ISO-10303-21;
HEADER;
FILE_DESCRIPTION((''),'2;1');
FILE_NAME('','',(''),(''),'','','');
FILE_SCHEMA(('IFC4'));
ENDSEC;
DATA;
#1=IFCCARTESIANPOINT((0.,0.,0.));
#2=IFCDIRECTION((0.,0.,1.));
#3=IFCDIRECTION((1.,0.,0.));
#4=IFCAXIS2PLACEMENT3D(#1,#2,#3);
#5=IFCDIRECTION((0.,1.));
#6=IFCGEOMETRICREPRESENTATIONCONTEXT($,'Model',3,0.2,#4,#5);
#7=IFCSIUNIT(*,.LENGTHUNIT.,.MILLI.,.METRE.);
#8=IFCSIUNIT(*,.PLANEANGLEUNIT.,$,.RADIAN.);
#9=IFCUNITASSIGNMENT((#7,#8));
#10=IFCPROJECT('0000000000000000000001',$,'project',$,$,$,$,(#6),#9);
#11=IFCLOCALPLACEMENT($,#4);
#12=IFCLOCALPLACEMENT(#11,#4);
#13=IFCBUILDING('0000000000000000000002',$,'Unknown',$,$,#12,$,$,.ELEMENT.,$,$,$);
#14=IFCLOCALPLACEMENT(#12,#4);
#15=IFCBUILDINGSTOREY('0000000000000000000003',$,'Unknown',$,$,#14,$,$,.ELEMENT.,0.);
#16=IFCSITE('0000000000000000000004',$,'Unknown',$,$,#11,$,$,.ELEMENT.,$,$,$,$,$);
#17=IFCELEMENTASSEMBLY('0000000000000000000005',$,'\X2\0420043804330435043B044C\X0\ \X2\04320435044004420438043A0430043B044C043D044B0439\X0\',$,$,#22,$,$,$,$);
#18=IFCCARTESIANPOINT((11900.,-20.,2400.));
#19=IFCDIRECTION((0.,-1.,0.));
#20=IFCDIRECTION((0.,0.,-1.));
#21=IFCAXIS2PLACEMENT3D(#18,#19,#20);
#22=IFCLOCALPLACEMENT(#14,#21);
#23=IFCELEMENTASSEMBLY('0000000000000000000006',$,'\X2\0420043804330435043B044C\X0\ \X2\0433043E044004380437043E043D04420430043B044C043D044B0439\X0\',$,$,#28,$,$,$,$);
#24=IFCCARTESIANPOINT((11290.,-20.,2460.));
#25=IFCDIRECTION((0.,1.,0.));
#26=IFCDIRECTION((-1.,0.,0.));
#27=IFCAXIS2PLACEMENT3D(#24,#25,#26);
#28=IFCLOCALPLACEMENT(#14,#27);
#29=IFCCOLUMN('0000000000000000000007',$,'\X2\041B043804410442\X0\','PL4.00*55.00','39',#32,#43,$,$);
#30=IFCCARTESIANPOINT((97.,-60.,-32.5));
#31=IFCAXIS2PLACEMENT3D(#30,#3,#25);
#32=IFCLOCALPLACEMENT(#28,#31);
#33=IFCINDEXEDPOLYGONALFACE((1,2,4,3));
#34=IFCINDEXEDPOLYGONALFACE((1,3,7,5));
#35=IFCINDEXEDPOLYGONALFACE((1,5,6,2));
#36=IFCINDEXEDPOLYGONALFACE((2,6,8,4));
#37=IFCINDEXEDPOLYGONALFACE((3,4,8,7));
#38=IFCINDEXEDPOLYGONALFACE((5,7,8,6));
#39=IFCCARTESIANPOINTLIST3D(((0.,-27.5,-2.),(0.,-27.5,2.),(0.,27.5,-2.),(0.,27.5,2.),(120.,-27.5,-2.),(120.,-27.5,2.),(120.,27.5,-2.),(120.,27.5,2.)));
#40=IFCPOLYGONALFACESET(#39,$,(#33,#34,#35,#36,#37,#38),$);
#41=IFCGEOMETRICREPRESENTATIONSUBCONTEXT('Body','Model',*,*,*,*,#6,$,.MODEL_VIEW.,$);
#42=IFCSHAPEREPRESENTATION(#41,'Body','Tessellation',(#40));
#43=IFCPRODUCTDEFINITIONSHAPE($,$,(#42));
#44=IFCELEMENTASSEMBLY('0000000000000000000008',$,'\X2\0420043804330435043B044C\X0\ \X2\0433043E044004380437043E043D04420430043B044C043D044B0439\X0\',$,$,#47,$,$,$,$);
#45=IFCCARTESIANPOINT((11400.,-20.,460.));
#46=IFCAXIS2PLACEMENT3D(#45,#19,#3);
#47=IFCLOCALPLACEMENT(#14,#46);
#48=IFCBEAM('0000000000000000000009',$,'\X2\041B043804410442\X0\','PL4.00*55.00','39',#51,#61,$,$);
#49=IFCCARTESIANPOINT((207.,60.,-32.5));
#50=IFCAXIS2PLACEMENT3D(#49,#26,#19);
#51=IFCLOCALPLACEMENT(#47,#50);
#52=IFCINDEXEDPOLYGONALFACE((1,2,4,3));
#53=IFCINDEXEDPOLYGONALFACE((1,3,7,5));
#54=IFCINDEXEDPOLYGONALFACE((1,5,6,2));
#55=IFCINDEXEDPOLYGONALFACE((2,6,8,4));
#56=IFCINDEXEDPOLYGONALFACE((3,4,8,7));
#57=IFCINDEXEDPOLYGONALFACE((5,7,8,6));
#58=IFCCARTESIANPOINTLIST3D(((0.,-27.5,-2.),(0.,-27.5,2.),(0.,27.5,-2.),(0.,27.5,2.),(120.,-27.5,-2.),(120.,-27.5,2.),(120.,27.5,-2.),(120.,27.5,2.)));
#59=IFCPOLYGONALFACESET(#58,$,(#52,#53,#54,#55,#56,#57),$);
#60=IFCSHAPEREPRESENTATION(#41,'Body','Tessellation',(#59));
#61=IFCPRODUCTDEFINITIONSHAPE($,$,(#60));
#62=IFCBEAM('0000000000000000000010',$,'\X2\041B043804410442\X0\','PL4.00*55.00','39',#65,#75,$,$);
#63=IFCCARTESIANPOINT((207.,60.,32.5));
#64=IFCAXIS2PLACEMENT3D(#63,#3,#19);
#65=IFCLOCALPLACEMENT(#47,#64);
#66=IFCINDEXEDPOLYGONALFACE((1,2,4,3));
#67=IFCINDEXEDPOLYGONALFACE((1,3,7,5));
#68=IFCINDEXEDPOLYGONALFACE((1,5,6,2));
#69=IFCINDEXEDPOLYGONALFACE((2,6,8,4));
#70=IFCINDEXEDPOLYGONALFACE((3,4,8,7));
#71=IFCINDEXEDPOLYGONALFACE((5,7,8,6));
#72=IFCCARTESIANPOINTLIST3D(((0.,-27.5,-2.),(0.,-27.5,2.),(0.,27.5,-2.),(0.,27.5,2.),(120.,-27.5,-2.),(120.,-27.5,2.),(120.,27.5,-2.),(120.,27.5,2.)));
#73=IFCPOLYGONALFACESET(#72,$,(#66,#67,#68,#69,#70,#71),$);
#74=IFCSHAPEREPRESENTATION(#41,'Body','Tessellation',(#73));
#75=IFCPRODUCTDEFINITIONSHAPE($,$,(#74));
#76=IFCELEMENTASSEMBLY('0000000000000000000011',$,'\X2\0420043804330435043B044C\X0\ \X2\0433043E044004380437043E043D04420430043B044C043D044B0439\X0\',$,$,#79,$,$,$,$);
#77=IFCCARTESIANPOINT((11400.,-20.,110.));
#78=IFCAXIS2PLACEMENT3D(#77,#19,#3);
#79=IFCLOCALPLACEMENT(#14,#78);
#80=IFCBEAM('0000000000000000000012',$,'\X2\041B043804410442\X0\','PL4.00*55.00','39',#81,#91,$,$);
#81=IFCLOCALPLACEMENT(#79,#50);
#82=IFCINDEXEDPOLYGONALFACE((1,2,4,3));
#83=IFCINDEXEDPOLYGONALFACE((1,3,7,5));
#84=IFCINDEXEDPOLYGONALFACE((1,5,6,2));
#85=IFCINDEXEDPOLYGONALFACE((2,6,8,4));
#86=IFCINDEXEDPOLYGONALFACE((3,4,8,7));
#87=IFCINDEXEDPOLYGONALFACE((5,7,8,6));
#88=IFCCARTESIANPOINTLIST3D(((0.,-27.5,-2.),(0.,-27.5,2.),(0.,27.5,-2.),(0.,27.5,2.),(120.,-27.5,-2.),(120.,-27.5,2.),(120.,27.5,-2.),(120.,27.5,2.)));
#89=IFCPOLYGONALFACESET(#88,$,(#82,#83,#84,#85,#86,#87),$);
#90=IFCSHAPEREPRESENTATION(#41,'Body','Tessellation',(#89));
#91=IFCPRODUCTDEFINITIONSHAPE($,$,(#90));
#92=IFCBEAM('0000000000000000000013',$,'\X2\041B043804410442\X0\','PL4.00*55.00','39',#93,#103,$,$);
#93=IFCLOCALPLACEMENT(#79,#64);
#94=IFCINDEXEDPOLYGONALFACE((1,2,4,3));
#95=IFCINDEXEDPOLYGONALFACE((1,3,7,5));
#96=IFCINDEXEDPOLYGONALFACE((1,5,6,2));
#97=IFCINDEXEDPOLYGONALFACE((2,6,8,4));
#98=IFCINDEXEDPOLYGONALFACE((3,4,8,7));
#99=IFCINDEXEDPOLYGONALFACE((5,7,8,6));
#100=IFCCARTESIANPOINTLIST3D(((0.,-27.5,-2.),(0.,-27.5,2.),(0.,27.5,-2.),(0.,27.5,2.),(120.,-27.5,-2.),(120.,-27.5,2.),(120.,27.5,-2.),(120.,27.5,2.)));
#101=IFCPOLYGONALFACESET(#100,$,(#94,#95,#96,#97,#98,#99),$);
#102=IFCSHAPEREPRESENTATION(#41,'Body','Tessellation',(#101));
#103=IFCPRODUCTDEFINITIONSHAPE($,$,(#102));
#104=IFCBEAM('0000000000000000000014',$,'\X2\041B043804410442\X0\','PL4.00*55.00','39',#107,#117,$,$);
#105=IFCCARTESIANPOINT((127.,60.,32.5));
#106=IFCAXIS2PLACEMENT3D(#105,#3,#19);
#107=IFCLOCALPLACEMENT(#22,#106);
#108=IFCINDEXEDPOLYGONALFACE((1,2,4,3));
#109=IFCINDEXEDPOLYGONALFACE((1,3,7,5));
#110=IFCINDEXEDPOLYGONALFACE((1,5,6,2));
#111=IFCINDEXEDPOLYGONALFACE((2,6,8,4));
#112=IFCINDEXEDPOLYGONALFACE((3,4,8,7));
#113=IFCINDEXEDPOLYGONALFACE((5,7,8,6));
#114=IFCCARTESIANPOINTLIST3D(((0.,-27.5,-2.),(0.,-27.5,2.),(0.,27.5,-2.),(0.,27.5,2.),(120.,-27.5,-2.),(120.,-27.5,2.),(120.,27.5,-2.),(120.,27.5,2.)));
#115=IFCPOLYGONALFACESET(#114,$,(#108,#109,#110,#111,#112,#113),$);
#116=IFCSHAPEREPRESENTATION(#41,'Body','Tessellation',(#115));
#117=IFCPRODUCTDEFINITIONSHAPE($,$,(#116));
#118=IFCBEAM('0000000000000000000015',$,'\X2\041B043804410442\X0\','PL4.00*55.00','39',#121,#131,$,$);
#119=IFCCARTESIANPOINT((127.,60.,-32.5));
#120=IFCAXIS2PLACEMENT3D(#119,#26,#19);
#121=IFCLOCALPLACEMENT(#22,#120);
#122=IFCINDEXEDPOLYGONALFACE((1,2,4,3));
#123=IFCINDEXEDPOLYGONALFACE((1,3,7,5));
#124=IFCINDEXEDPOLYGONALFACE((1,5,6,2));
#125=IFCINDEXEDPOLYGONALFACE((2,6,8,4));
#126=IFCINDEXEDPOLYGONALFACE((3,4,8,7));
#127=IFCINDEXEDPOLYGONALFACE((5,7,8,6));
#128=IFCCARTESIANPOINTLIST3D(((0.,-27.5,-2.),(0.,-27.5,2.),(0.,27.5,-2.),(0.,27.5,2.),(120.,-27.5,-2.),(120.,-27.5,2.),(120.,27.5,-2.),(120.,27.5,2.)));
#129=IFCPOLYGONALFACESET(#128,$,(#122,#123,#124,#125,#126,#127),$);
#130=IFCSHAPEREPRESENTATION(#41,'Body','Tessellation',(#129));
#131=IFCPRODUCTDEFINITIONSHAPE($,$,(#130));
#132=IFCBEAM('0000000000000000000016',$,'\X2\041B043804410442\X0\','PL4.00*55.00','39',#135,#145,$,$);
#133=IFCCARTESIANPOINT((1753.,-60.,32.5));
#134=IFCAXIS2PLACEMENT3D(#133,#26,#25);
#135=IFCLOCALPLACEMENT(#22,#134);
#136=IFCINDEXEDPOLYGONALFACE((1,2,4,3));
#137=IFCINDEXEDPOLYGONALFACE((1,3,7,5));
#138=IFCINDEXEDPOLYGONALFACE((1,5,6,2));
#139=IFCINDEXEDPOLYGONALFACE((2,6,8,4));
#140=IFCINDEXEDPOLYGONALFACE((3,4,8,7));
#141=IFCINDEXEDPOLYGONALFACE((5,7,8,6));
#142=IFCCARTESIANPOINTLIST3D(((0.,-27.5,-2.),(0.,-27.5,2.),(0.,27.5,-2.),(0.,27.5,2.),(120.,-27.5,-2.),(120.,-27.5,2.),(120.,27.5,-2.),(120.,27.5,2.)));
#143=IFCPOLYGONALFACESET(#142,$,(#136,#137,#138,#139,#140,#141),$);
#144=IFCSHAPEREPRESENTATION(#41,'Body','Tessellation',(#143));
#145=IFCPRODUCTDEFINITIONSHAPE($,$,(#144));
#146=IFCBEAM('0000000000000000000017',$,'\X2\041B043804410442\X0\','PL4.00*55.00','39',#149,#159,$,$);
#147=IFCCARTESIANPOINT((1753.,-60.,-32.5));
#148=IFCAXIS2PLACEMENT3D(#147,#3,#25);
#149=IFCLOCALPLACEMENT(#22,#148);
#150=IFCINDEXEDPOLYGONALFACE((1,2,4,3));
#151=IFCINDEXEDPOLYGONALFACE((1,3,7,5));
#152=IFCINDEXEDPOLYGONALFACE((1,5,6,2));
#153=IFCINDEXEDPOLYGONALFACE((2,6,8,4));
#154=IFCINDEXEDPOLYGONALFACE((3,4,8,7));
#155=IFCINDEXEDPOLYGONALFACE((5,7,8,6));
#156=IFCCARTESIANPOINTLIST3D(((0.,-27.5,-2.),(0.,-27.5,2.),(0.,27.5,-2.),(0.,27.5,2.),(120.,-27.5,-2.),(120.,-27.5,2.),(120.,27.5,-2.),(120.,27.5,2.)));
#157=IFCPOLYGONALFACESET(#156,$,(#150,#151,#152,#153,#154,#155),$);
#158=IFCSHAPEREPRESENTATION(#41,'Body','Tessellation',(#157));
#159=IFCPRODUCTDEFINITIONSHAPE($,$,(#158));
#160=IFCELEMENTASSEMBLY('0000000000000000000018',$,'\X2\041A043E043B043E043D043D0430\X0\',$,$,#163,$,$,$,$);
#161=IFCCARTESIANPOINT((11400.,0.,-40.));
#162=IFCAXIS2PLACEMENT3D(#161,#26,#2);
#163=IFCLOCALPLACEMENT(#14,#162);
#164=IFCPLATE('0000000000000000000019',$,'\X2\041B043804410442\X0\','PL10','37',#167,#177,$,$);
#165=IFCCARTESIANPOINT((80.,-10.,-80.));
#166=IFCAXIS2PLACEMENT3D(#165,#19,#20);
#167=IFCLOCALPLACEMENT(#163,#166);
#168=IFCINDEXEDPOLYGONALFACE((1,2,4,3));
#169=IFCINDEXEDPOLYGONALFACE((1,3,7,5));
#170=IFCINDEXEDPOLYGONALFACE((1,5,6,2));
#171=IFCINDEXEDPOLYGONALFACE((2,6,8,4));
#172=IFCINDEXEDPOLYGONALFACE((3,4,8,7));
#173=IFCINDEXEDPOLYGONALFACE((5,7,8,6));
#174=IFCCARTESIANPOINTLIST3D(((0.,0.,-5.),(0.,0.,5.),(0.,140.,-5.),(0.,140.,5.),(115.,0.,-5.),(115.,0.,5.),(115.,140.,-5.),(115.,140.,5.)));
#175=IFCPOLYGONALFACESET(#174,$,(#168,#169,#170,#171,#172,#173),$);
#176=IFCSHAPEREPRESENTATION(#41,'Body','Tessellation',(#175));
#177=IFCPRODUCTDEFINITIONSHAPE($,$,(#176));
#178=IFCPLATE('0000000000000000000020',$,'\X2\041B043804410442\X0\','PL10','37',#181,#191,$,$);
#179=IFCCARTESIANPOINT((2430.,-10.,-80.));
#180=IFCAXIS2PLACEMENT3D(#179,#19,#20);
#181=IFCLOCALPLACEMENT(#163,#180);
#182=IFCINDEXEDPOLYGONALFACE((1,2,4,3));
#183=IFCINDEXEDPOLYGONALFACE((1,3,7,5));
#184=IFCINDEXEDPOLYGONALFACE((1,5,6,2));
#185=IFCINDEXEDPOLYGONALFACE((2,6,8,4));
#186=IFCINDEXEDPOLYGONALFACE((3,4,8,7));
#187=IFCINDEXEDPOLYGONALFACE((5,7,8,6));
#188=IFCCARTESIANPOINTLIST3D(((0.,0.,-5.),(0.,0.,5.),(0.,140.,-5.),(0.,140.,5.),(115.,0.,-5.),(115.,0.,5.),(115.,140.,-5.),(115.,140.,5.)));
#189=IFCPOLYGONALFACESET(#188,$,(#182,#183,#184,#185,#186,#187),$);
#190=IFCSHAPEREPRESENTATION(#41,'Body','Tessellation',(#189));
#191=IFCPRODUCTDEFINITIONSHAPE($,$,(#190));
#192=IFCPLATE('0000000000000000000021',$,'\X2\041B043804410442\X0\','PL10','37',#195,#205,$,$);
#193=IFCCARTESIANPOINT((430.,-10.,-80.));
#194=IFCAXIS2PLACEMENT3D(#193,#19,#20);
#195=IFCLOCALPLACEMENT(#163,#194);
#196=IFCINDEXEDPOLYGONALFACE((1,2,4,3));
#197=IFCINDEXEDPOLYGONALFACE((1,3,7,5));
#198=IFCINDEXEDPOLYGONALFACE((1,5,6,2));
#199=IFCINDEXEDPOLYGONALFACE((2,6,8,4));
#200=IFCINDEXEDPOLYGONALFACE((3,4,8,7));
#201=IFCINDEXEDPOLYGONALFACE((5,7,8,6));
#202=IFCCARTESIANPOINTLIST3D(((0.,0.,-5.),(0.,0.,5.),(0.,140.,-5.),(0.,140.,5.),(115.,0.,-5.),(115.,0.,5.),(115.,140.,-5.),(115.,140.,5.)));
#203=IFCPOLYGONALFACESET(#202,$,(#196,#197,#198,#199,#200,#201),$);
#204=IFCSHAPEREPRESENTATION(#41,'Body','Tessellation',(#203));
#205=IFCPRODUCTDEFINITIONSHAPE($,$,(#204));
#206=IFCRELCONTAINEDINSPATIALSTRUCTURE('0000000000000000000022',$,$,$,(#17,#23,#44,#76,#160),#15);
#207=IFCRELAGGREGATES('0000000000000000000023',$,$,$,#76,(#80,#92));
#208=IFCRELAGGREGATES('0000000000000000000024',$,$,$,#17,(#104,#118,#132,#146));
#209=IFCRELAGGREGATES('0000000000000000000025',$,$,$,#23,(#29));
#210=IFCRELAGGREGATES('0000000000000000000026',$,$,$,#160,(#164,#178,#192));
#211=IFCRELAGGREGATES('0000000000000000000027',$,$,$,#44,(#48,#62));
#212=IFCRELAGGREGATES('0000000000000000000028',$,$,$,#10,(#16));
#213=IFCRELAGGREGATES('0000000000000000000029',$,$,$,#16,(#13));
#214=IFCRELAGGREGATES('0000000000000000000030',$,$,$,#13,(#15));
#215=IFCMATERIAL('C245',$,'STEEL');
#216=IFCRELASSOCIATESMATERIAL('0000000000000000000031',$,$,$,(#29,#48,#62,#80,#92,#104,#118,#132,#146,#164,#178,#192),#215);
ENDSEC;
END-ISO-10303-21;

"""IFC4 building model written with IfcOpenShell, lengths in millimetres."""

from ifc_helpers import new_model, si_unit, direction, frame, origin_with_axes, place, context, subcontext, project, spatial, line, indexed_curve, outline, extrude, material, element, aggregate, save


model = new_model("IFC4")

# Units and contexts
model_context = context("Model", 3, precision=0.2, world=origin_with_axes(), true_north=direction((0.0, 1.0)))
body_context = subcontext(model_context, "Body", "Model", "MODEL_VIEW")
ifc_project = project(units=[si_unit("LENGTHUNIT", "METRE", prefix="MILLI"), si_unit("PLANEANGLEUNIT", "RADIAN")], contexts=[model_context])

# Site, building, storey
site_placement = place(None, origin_with_axes())
site = spatial("IfcSite", under=ifc_project, at=site_placement, Name="Unknown", CompositionType="ELEMENT")
building_placement = place(site_placement, origin_with_axes())
building = spatial("IfcBuilding", under=site, at=building_placement, Name="Unknown", CompositionType="ELEMENT")
storey_placement = place(building_placement, origin_with_axes())
storey = spatial("IfcBuildingStorey", under=building, at=storey_placement, Name="Unknown", CompositionType="ELEMENT", Elevation=0.0)

# Element assemblies, column
ifc_material_1 = material(Name="C245", Category="STEEL")
assembly_1_placement = place(storey_placement, frame((11900.0, -20.0, 2400.0), z_axis=(0.0, -1.0, 0.0), x_axis=(0.0, 0.0, -1.0)))
assembly_1 = element("IfcElementAssembly", 1, at=assembly_1_placement, inside=storey, Name="Ригель вертикальный")
assembly_2_placement = place(storey_placement, frame((11290.0, -20.0, 2460.0), z_axis=(0.0, 1.0, 0.0), x_axis=(-1.0, 0.0, 0.0)))
assembly_2 = element("IfcElementAssembly", 2, at=assembly_2_placement, inside=storey, Name="Ригель горизонтальный")
column_1_placement = place(assembly_2_placement, frame((97.0, -60.0, -32.5), z_axis=(1.0, 0.0, 0.0), x_axis=(0.0, 1.0, 0.0)))
column_1 = element("IfcColumn", 3, at=column_1_placement, material=ifc_material_1, Name="Лист", Description="PL4.00*55.00", ObjectType="39", context=body_context, shape_type="SolidModel", body=[
    extrude(outline(indexed_curve([(-2.0, -27.5), (2.0, -27.5), (2.0, 27.5), (-2.0, 27.5)], segments=[line(1, 2, 3, 4, 1)])), frame((0.0, 0.0, 0.0), z_axis=(-1.0, 0.0, 0.0), x_axis=(0.0, 0.0, 1.0)), (0.0, 0.0, -1.0), 120.0),
])

# Element assemblies, beams
assembly_3_placement = place(storey_placement, frame((11400.0, -20.0, 460.0), z_axis=(0.0, -1.0, 0.0), x_axis=(1.0, 0.0, 0.0)))
assembly_3 = element("IfcElementAssembly", 4, at=assembly_3_placement, inside=storey, Name="Ригель горизонтальный")
beam_1_placement = place(assembly_3_placement, frame((207.0, 60.0, -32.5), z_axis=(-1.0, 0.0, 0.0), x_axis=(0.0, -1.0, 0.0)))
beam_1 = element("IfcBeam", 5, at=beam_1_placement, material=ifc_material_1, Name="Лист", Description="PL4.00*55.00", ObjectType="39", context=body_context, shape_type="SolidModel", body=[
    extrude(outline(indexed_curve([(-2.0, -27.5), (2.0, -27.5), (2.0, 27.5), (-2.0, 27.5)], segments=[line(1, 2, 3, 4, 1)])), frame((0.0, 0.0, 0.0), z_axis=(-1.0, 0.0, 0.0), x_axis=(0.0, 0.0, 1.0)), (0.0, 0.0, -1.0), 120.0),
])
beam_2_placement = place(assembly_3_placement, frame((207.0, 60.0, 32.5), z_axis=(1.0, 0.0, 0.0), x_axis=(0.0, -1.0, 0.0)))
beam_2 = element("IfcBeam", 6, at=beam_2_placement, material=ifc_material_1, Name="Лист", Description="PL4.00*55.00", ObjectType="39", context=body_context, shape_type="SolidModel", body=[
    extrude(outline(indexed_curve([(-2.0, -27.5), (2.0, -27.5), (2.0, 27.5), (-2.0, 27.5)], segments=[line(1, 2, 3, 4, 1)])), frame((0.0, 0.0, 0.0), z_axis=(-1.0, 0.0, 0.0), x_axis=(0.0, 0.0, 1.0)), (0.0, 0.0, -1.0), 120.0),
])
assembly_4_placement = place(storey_placement, frame((11400.0, -20.0, 110.0), z_axis=(0.0, -1.0, 0.0), x_axis=(1.0, 0.0, 0.0)))
assembly_4 = element("IfcElementAssembly", 7, at=assembly_4_placement, inside=storey, Name="Ригель горизонтальный")
beam_3_placement = place(assembly_4_placement, frame((207.0, 60.0, -32.5), z_axis=(-1.0, 0.0, 0.0), x_axis=(0.0, -1.0, 0.0)))
beam_3 = element("IfcBeam", 8, at=beam_3_placement, material=ifc_material_1, Name="Лист", Description="PL4.00*55.00", ObjectType="39", context=body_context, shape_type="SolidModel", body=[
    extrude(outline(indexed_curve([(-2.0, -27.5), (2.0, -27.5), (2.0, 27.5), (-2.0, 27.5)], segments=[line(1, 2, 3, 4, 1)])), frame((0.0, 0.0, 0.0), z_axis=(-1.0, 0.0, 0.0), x_axis=(0.0, 0.0, 1.0)), (0.0, 0.0, -1.0), 120.0),
])
beam_4_placement = place(assembly_4_placement, frame((207.0, 60.0, 32.5), z_axis=(1.0, 0.0, 0.0), x_axis=(0.0, -1.0, 0.0)))
beam_4 = element("IfcBeam", 9, at=beam_4_placement, material=ifc_material_1, Name="Лист", Description="PL4.00*55.00", ObjectType="39", context=body_context, shape_type="SolidModel", body=[
    extrude(outline(indexed_curve([(-2.0, -27.5), (2.0, -27.5), (2.0, 27.5), (-2.0, 27.5)], segments=[line(1, 2, 3, 4, 1)])), frame((0.0, 0.0, 0.0), z_axis=(-1.0, 0.0, 0.0), x_axis=(0.0, 0.0, 1.0)), (0.0, 0.0, -1.0), 120.0),
])
aggregate(assembly_4, [beam_3, beam_4])

# Beams
beam_5_placement = place(assembly_1_placement, frame((127.0, 60.0, 32.5), z_axis=(1.0, 0.0, 0.0), x_axis=(0.0, -1.0, 0.0)))
beam_5 = element("IfcBeam", 10, at=beam_5_placement, material=ifc_material_1, Name="Лист", Description="PL4.00*55.00", ObjectType="39", context=body_context, shape_type="SolidModel", body=[
    extrude(outline(indexed_curve([(-2.0, -27.5), (2.0, -27.5), (2.0, 27.5), (-2.0, 27.5)], segments=[line(1, 2, 3, 4, 1)])), frame((0.0, 0.0, 0.0), z_axis=(-1.0, 0.0, 0.0), x_axis=(0.0, 0.0, 1.0)), (0.0, 0.0, -1.0), 120.0),
])
beam_6_placement = place(assembly_1_placement, frame((127.0, 60.0, -32.5), z_axis=(-1.0, 0.0, 0.0), x_axis=(0.0, -1.0, 0.0)))
beam_6 = element("IfcBeam", 11, at=beam_6_placement, material=ifc_material_1, Name="Лист", Description="PL4.00*55.00", ObjectType="39", context=body_context, shape_type="SolidModel", body=[
    extrude(outline(indexed_curve([(-2.0, -27.5), (2.0, -27.5), (2.0, 27.5), (-2.0, 27.5)], segments=[line(1, 2, 3, 4, 1)])), frame((0.0, 0.0, 0.0), z_axis=(-1.0, 0.0, 0.0), x_axis=(0.0, 0.0, 1.0)), (0.0, 0.0, -1.0), 120.0),
])
beam_7_placement = place(assembly_1_placement, frame((1753.0, -60.0, 32.5), z_axis=(-1.0, 0.0, 0.0), x_axis=(0.0, 1.0, 0.0)))
beam_7 = element("IfcBeam", 12, at=beam_7_placement, material=ifc_material_1, Name="Лист", Description="PL4.00*55.00", ObjectType="39", context=body_context, shape_type="SolidModel", body=[
    extrude(outline(indexed_curve([(-2.0, -27.5), (2.0, -27.5), (2.0, 27.5), (-2.0, 27.5)], segments=[line(1, 2, 3, 4, 1)])), frame((0.0, 0.0, 0.0), z_axis=(-1.0, 0.0, 0.0), x_axis=(0.0, 0.0, 1.0)), (0.0, 0.0, -1.0), 120.0),
])
beam_8_placement = place(assembly_1_placement, frame((1753.0, -60.0, -32.5), z_axis=(1.0, 0.0, 0.0), x_axis=(0.0, 1.0, 0.0)))
beam_8 = element("IfcBeam", 13, at=beam_8_placement, material=ifc_material_1, Name="Лист", Description="PL4.00*55.00", ObjectType="39", context=body_context, shape_type="SolidModel", body=[
    extrude(outline(indexed_curve([(-2.0, -27.5), (2.0, -27.5), (2.0, 27.5), (-2.0, 27.5)], segments=[line(1, 2, 3, 4, 1)])), frame((0.0, 0.0, 0.0), z_axis=(-1.0, 0.0, 0.0), x_axis=(0.0, 0.0, 1.0)), (0.0, 0.0, -1.0), 120.0),
])
aggregate(assembly_1, [beam_5, beam_6, beam_7, beam_8])

# Element assembly, plates
assembly_5_placement = place(storey_placement, frame((11400.0, 0.0, -40.0), z_axis=(-1.0, 0.0, 0.0), x_axis=(0.0, 0.0, 1.0)))
assembly_5 = element("IfcElementAssembly", 14, at=assembly_5_placement, inside=storey, Name="Колонна")
plate_1_placement = place(assembly_5_placement, frame((80.0, -10.0, -80.0), z_axis=(0.0, -1.0, 0.0), x_axis=(0.0, 0.0, -1.0)))
plate_1 = element("IfcPlate", 15, at=plate_1_placement, material=ifc_material_1, Name="Лист", Description="PL10", ObjectType="37", context=body_context, shape_type="SolidModel", body=[
    extrude(outline(indexed_curve([(0.0, 0.0), (115.0, 0.0), (115.0, 140.0), (0.0, 140.0)], segments=[line(1, 2, 3, 4, 1)])), frame((0.0, 0.0, 5.0), z_axis=(0.0, 0.0, 1.0), x_axis=(1.0, 0.0, 0.0)), (0.0, 0.0, -1.0), 10.0),
])
plate_2_placement = place(assembly_5_placement, frame((2430.0, -10.0, -80.0), z_axis=(0.0, -1.0, 0.0), x_axis=(0.0, 0.0, -1.0)))
plate_2 = element("IfcPlate", 16, at=plate_2_placement, material=ifc_material_1, Name="Лист", Description="PL10", ObjectType="37", context=body_context, shape_type="SolidModel", body=[
    extrude(outline(indexed_curve([(0.0, 0.0), (115.0, 0.0), (115.0, 140.0), (0.0, 140.0)], segments=[line(1, 2, 3, 4, 1)])), frame((0.0, 0.0, 5.0), z_axis=(0.0, 0.0, 1.0), x_axis=(1.0, 0.0, 0.0)), (0.0, 0.0, -1.0), 10.0),
])
plate_3_placement = place(assembly_5_placement, frame((430.0, -10.0, -80.0), z_axis=(0.0, -1.0, 0.0), x_axis=(0.0, 0.0, -1.0)))
plate_3 = element("IfcPlate", 17, at=plate_3_placement, material=ifc_material_1, Name="Лист", Description="PL10", ObjectType="37", context=body_context, shape_type="SolidModel", body=[
    extrude(outline(indexed_curve([(0.0, 0.0), (115.0, 0.0), (115.0, 140.0), (0.0, 140.0)], segments=[line(1, 2, 3, 4, 1)])), frame((0.0, 0.0, 5.0), z_axis=(0.0, 0.0, 1.0), x_axis=(1.0, 0.0, 0.0)), (0.0, 0.0, -1.0), 10.0),
])

aggregate(assembly_2, [column_1])

aggregate(assembly_5, [plate_1, plate_2, plate_3])
aggregate(assembly_3, [beam_1, beam_2])

save(model, "model.ifc")
